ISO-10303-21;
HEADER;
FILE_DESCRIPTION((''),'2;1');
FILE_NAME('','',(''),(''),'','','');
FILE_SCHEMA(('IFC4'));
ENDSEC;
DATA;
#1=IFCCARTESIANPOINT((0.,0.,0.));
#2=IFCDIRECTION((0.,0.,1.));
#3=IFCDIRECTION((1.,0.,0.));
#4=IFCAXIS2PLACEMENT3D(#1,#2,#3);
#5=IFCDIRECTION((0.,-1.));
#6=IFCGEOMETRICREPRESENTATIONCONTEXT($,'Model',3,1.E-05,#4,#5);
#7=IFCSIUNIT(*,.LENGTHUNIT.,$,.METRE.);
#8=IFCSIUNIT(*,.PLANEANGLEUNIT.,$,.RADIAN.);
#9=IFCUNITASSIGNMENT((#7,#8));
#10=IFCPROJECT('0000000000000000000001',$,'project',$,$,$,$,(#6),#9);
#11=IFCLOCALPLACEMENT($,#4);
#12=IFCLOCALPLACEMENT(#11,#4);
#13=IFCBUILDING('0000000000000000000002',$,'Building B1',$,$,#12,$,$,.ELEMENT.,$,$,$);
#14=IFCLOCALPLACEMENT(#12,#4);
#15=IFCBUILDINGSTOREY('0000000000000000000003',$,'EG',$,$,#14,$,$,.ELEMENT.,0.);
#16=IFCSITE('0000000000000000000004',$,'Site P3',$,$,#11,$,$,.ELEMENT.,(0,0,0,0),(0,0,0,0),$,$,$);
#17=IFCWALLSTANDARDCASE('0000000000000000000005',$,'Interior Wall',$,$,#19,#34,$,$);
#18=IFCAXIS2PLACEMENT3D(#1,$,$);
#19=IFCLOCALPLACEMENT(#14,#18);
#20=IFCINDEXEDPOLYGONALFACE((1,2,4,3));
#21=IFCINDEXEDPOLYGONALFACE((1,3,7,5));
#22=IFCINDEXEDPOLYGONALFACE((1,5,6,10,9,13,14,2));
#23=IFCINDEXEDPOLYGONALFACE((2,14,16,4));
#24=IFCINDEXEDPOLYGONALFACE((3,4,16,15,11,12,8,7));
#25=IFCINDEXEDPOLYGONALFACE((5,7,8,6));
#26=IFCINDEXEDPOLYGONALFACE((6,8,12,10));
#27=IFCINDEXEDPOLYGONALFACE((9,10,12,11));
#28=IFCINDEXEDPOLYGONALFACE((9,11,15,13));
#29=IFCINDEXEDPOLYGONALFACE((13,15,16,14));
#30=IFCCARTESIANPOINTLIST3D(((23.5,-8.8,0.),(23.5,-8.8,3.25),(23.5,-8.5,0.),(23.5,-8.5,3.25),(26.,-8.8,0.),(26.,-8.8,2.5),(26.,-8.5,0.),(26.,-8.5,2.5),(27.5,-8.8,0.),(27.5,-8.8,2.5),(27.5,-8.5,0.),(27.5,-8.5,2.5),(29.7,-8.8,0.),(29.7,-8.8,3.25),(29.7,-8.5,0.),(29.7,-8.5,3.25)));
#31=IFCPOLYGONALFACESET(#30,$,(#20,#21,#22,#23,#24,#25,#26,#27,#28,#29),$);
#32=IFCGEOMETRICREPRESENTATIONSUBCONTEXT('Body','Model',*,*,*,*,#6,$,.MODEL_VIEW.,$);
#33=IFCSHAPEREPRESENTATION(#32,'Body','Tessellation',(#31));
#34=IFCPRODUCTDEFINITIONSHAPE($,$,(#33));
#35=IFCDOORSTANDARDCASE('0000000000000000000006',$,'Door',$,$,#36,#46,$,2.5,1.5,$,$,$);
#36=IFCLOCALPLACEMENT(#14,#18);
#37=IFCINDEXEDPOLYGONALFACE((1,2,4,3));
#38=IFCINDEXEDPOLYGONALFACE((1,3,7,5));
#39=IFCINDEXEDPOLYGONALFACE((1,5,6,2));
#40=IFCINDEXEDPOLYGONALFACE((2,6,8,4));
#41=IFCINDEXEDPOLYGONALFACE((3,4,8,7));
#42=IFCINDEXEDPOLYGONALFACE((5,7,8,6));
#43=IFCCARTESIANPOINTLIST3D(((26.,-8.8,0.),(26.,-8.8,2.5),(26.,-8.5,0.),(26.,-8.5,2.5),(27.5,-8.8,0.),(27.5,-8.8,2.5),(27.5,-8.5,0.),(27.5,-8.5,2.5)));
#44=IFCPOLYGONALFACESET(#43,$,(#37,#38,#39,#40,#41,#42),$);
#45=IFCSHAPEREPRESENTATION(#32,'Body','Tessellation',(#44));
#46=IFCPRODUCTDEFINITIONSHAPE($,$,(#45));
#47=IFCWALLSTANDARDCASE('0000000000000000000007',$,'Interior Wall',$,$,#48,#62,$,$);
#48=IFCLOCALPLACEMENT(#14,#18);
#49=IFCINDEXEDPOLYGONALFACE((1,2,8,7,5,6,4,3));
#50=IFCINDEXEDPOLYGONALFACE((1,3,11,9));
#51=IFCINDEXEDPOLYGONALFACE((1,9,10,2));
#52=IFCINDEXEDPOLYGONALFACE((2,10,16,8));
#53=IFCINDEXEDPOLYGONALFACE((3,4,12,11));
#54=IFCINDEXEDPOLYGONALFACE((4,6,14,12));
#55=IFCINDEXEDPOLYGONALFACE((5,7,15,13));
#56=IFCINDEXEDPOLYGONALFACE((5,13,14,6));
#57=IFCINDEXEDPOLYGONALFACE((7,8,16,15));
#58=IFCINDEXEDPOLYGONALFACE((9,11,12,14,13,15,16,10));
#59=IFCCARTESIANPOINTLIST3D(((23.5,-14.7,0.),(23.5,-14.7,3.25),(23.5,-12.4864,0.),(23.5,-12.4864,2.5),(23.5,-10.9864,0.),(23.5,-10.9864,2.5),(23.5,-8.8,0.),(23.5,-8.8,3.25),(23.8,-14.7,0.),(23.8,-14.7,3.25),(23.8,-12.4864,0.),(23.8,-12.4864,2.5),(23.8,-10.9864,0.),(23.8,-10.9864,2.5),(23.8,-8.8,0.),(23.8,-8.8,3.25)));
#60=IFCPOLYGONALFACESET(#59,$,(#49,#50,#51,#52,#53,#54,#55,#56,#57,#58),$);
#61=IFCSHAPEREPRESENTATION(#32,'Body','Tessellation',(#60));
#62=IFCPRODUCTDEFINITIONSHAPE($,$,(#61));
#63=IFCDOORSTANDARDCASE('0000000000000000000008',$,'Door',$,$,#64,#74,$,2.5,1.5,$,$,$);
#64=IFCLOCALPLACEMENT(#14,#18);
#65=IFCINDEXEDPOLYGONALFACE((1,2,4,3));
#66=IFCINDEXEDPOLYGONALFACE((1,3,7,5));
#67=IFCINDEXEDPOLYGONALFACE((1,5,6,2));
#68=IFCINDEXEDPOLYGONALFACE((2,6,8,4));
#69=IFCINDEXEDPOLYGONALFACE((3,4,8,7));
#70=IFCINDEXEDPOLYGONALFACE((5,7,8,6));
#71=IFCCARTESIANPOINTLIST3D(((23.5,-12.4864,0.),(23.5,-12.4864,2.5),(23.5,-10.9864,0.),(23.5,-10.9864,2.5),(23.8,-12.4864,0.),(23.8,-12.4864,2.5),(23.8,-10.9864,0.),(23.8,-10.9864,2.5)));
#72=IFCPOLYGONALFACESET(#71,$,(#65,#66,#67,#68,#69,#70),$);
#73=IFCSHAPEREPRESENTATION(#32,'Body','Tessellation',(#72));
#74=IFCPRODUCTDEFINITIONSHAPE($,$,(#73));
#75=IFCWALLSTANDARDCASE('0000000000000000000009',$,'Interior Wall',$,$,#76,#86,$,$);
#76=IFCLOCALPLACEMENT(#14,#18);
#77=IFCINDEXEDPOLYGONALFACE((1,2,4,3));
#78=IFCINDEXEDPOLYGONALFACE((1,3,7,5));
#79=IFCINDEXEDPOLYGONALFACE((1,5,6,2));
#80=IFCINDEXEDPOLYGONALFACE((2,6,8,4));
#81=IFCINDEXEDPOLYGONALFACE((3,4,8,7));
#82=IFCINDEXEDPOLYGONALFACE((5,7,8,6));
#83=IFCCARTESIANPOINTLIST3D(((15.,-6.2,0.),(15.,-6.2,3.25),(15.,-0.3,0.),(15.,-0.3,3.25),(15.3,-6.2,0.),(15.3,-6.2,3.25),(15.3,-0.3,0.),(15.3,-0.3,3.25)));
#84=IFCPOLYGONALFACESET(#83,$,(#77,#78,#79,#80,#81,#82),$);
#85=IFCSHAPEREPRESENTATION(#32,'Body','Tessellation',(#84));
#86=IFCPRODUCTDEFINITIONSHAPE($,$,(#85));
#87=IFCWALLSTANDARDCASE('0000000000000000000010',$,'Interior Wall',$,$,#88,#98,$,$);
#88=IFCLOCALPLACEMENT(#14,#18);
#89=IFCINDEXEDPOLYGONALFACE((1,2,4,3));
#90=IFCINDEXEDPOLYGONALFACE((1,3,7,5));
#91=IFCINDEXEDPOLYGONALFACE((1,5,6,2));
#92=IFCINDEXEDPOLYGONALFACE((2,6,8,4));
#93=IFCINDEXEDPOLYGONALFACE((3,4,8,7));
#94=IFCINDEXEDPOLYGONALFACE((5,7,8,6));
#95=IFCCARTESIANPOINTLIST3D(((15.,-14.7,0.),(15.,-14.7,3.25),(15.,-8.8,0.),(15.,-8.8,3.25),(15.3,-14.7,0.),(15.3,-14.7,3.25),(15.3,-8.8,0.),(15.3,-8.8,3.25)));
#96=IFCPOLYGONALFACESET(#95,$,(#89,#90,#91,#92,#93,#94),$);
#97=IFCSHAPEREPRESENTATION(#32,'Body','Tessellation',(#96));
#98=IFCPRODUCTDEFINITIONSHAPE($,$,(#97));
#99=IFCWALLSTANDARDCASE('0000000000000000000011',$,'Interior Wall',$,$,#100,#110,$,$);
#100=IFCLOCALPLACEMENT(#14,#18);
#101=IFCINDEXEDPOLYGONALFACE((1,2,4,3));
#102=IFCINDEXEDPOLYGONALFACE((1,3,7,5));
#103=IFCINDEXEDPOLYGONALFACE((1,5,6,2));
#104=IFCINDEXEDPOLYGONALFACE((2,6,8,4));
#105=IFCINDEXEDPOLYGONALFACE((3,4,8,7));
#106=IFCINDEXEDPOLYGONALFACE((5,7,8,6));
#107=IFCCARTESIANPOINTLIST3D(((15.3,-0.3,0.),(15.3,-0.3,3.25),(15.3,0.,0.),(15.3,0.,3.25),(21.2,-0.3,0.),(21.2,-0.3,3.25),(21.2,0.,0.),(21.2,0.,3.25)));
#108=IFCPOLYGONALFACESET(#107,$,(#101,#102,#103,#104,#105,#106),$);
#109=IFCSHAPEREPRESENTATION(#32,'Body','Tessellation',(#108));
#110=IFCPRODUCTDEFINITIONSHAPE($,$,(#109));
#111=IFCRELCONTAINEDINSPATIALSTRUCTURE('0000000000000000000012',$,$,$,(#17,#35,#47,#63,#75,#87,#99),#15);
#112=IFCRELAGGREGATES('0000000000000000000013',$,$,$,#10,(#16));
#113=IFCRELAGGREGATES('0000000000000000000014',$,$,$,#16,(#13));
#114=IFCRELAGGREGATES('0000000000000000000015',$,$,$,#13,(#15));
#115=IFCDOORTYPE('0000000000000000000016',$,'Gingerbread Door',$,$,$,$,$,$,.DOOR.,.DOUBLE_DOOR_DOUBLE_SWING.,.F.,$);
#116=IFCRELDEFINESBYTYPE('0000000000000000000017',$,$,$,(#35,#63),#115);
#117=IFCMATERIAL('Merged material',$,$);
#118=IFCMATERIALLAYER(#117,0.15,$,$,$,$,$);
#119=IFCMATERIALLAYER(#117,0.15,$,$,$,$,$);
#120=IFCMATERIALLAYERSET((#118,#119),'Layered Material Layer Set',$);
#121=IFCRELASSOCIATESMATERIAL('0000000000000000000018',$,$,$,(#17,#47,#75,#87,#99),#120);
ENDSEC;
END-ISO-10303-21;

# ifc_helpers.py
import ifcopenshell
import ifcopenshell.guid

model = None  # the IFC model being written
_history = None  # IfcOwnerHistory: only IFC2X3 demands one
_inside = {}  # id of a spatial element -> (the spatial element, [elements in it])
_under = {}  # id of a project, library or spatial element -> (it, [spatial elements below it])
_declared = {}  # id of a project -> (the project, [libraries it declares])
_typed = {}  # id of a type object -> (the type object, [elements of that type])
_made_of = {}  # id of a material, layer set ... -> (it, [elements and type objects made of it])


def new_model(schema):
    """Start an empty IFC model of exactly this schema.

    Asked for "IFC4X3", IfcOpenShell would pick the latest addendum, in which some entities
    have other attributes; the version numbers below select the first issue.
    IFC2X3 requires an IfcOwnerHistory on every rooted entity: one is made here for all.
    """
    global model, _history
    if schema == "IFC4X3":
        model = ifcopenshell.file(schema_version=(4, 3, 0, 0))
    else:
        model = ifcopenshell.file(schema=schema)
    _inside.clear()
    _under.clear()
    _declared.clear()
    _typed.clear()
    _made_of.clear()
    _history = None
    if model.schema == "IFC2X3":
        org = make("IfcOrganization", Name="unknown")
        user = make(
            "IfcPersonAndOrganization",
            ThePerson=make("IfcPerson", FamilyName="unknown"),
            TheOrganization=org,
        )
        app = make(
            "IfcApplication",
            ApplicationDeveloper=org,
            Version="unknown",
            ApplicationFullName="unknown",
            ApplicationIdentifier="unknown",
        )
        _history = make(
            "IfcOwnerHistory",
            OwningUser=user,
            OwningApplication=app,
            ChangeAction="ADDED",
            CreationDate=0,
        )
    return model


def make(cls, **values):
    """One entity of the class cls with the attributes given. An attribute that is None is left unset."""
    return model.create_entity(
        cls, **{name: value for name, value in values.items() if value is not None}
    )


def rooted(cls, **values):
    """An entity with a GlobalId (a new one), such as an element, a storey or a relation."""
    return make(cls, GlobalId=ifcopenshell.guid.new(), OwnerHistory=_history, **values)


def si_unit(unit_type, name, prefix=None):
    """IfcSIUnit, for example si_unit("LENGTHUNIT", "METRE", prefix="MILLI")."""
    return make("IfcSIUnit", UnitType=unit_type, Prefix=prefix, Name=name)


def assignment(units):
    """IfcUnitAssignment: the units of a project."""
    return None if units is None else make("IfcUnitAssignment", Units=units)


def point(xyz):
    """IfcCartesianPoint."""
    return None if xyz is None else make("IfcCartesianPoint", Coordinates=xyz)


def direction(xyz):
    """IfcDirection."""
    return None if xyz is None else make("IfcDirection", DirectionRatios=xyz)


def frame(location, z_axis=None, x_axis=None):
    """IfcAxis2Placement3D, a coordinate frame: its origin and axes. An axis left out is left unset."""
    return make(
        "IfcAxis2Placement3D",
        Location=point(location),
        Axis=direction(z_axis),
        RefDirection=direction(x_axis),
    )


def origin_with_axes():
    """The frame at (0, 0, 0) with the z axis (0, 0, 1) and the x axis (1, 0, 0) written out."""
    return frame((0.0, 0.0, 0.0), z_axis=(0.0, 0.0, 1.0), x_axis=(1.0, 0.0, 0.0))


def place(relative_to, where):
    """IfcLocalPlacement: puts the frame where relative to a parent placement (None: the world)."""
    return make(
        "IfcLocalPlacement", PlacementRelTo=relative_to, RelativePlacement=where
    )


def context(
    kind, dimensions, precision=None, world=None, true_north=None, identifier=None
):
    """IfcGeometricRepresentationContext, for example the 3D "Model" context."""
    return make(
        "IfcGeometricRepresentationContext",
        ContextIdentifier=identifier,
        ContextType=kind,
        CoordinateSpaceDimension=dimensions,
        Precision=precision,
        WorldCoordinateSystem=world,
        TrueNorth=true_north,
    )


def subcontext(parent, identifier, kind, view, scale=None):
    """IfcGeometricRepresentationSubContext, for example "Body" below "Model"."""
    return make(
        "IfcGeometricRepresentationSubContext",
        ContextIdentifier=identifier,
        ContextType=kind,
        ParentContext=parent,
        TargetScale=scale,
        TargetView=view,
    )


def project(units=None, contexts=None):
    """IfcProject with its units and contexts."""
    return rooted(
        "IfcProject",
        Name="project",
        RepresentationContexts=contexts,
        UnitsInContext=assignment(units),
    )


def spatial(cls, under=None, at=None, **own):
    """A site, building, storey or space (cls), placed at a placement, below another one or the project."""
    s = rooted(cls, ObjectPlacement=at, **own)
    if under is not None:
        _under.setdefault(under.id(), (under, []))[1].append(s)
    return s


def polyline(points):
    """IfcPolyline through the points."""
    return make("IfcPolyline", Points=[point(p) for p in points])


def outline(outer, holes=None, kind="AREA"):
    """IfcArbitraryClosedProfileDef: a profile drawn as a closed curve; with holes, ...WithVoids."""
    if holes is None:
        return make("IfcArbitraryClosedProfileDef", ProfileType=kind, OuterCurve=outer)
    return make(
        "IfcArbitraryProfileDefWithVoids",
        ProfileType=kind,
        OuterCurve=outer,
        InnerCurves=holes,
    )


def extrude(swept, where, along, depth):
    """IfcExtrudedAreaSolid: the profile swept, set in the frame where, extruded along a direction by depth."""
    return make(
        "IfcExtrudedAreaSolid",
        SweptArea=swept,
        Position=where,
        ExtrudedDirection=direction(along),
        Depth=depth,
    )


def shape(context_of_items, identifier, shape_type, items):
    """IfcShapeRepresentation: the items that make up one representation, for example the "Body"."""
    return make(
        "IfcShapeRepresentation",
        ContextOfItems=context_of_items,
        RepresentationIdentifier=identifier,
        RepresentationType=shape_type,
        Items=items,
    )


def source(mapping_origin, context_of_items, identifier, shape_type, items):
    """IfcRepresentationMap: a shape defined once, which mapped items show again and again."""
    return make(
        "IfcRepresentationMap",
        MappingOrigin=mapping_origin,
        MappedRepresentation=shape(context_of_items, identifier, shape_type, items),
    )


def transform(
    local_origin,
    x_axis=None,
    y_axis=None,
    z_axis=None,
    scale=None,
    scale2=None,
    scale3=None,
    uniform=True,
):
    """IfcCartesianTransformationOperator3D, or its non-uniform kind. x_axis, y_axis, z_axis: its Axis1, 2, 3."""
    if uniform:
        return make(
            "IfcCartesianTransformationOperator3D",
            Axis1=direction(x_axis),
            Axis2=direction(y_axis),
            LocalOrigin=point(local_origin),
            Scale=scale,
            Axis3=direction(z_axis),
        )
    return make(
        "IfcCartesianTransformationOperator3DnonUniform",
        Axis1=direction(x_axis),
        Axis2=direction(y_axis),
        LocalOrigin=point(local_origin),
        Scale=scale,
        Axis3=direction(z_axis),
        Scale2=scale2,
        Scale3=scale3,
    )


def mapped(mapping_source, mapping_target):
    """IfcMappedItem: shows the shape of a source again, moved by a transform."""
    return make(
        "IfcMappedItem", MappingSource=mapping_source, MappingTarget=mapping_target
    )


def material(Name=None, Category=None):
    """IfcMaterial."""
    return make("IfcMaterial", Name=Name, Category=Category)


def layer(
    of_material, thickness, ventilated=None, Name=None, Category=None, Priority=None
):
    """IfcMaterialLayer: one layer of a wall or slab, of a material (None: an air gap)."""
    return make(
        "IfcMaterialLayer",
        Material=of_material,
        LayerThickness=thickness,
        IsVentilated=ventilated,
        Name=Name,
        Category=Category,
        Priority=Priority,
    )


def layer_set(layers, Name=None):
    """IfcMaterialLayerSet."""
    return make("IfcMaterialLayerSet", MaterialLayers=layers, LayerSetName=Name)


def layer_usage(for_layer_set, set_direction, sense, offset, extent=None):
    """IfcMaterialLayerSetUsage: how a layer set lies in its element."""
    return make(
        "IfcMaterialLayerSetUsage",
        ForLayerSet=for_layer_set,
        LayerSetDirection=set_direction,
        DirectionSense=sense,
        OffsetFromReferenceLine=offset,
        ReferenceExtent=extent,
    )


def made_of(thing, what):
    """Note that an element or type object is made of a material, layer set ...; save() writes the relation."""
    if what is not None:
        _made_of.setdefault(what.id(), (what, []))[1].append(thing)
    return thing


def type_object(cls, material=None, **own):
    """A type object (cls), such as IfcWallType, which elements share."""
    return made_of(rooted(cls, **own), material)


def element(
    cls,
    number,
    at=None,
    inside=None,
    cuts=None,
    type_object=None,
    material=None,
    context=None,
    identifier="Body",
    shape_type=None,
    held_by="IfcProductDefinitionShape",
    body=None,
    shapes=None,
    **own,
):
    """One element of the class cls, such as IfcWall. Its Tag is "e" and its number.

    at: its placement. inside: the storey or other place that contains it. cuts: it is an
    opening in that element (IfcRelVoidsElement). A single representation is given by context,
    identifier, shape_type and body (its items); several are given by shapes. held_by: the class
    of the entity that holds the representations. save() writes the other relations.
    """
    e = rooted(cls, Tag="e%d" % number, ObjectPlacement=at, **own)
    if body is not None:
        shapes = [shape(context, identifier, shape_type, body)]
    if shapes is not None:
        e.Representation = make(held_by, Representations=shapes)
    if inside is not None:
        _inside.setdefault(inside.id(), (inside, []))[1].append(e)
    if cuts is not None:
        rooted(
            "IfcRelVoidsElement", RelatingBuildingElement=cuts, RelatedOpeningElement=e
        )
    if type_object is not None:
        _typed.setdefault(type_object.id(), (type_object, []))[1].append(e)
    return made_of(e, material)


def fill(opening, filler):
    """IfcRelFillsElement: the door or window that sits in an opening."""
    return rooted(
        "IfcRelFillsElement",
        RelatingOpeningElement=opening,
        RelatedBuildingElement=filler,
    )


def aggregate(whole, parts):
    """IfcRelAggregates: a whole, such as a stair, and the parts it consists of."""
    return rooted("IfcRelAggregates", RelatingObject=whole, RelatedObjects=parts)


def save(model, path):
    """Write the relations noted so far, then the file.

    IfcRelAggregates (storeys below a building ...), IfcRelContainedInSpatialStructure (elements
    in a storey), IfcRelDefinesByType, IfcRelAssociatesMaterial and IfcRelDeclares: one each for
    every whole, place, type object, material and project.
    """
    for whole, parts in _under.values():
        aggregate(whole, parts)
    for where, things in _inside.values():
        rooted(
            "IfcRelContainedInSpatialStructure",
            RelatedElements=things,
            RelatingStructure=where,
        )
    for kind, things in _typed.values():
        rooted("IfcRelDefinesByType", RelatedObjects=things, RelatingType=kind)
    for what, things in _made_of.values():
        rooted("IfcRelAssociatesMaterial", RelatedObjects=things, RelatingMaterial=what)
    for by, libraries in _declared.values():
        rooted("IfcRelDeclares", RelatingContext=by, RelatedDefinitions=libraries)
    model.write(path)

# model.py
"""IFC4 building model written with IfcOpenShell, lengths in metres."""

from ifc_helpers import new_model, si_unit, direction, frame, origin_with_axes, place, context, subcontext, project, spatial, polyline, outline, extrude, source, transform, mapped, material, layer, layer_set, layer_usage, type_object, element, fill, save


model = new_model("IFC4")

# Units and contexts
model_context = context("Model", 3, precision=1e-05, world=origin_with_axes(), true_north=direction((0.0, -1.0)))
body_context = subcontext(model_context, "Body", "Model", "MODEL_VIEW")
ifc_project = project(units=[si_unit("LENGTHUNIT", "METRE"), si_unit("PLANEANGLEUNIT", "RADIAN")], contexts=[model_context])

# Site, building, storey
site_placement = place(None, origin_with_axes())
site = spatial("IfcSite", under=ifc_project, at=site_placement, Name="Site P3", CompositionType="ELEMENT", RefLatitude=(0, 0, 0, 0), RefLongitude=(0, 0, 0, 0))
building_placement = place(site_placement, origin_with_axes())
building = spatial("IfcBuilding", under=site, at=building_placement, Name="Building B1", CompositionType="ELEMENT")
storey_placement = place(building_placement, origin_with_axes())
storey = spatial("IfcBuildingStorey", under=building, at=storey_placement, Name="EG", CompositionType="ELEMENT", Elevation=0.0)

# Shared definitions
ifc_material = material(Name="Merged material")

# Walls, openings, doors
ifc_layer_1 = layer(ifc_material, 0.15)
ifc_layer_2 = layer(ifc_material, 0.15)
ifc_layer_set_1 = layer_set([ifc_layer_1, ifc_layer_2], Name="Layered Material Layer Set")
ifc_layer_usage_1 = layer_usage(ifc_layer_set_1, "AXIS2", "POSITIVE", -0.15)
door_type = type_object("IfcDoorType", Name="Gingerbread Door", OperationType="DOUBLE_DOOR_DOUBLE_SWING", ParameterTakesPrecedence=False, PredefinedType="DOOR")
shared_shape_1 = source(origin_with_axes(), body_context, "Body", "SweptSolid", [
    extrude(outline(polyline([(0.0, 0.0), (0.0, 1.5), (2.5, 1.5), (2.5, 0.0), (0.0, 0.0)])), frame((0.0, -0.15, 0.0), z_axis=(0.0, 1.0, 0.0), x_axis=(0.0, 0.0, 1.0)), (0.0, 0.0, 1.0), 0.3),
])
wall_1_placement = place(storey_placement, frame((23.5, -8.65, 0.0), z_axis=(0.0, 0.0, 1.0), x_axis=(1.0, 0.0, 0.0)))
wall_1 = element("IfcWallStandardCase", 1, at=wall_1_placement, inside=storey, material=ifc_layer_usage_1, Name="Interior Wall", context=body_context, shape_type="SweptSolid", body=[
    extrude(outline(polyline([(0.0, 0.15), (6.2, 0.15), (6.2, -0.15), (0.0, -0.15), (0.0, 0.15)])), origin_with_axes(), (0.0, 0.0, 1.0), 3.25),
])
opening_1_placement = place(wall_1_placement, frame((2.5, 0.0, 0.0), z_axis=(0.0, 0.0, 1.0), x_axis=(1.0, 0.0, 0.0)))
opening_1 = element("IfcOpeningStandardCase", 2, at=opening_1_placement, cuts=wall_1, context=body_context, shape_type="SweptSolid", body=[
    extrude(outline(polyline([(0.0, 0.0), (0.0, 1.5), (2.5, 1.5), (2.5, 0.0), (0.0, 0.0)])), frame((0.0, -0.15, 0.0), z_axis=(0.0, 1.0, 0.0), x_axis=(0.0, 0.0, 1.0)), (0.0, 0.0, 1.0), 0.3),
])
door_1_placement = place(opening_1_placement, origin_with_axes())
door_1 = element("IfcDoorStandardCase", 3, at=door_1_placement, inside=storey, type_object=door_type, Name="Door", OverallHeight=2.5, OverallWidth=1.5, context=body_context, shape_type="MappedRepresentation", body=[
    mapped(shared_shape_1, transform((0.0, 0.0, 0.0))),
])
fill(opening_1, door_1)
wall_2_placement = place(storey_placement, frame((23.65, -8.8, 0.0), z_axis=(0.0, 0.0, 1.0), x_axis=(0.0, -1.0, 0.0)))
wall_2 = element("IfcWallStandardCase", 4, at=wall_2_placement, inside=storey, material=ifc_layer_usage_1, Name="Interior Wall", context=body_context, shape_type="SweptSolid", body=[
    extrude(outline(polyline([(0.0, 0.15), (5.9, 0.15), (5.9, -0.15), (0.0, -0.15), (0.0, 0.15)])), origin_with_axes(), (0.0, 0.0, 1.0), 3.25),
])
opening_2_placement = place(wall_2_placement, frame((2.1864, 0.0, 0.0), z_axis=(0.0, 0.0, 1.0), x_axis=(1.0, 0.0, 0.0)))
opening_2 = element("IfcOpeningStandardCase", 5, at=opening_2_placement, cuts=wall_2, context=body_context, shape_type="SweptSolid", body=[
    extrude(outline(polyline([(0.0, 0.0), (0.0, 1.5), (2.5, 1.5), (2.5, 0.0), (0.0, 0.0)])), frame((0.0, -0.15, 0.0), z_axis=(0.0, 1.0, 0.0), x_axis=(0.0, 0.0, 1.0)), (0.0, 0.0, 1.0), 0.3),
])
door_2_placement = place(opening_2_placement, origin_with_axes())
door_2 = element("IfcDoorStandardCase", 6, at=door_2_placement, inside=storey, type_object=door_type, Name="Door", OverallHeight=2.5, OverallWidth=1.5, context=body_context, shape_type="MappedRepresentation", body=[
    mapped(shared_shape_1, transform((0.0, 0.0, 0.0))),
])
fill(opening_2, door_2)

# Walls
for number, where, z_axis, x_axis, name in (
    (7, (15.15, -0.3, 0.0), (0.0, 0.0, 1.0), (0.0, -1.0, 0.0), "Interior Wall"),
    (8, (15.15, -8.8, 0.0), (0.0, 0.0, 1.0), (0.0, -1.0, 0.0), "Interior Wall"),
    (9, (15.3, -0.15, 0.0), (0.0, 0.0, 1.0), (1.0, 0.0, 0.0), "Interior Wall"),
):
    element("IfcWallStandardCase", number, at=place(storey_placement, frame(where, z_axis=z_axis, x_axis=x_axis)), inside=storey, material=ifc_layer_usage_1, Name=name, context=body_context, shape_type="SweptSolid", body=[
        extrude(outline(polyline([(0.0, 0.15), (5.9, 0.15), (5.9, -0.15), (0.0, -0.15), (0.0, 0.15)])), origin_with_axes(), (0.0, 0.0, 1.0), 3.25),
    ])

save(model, "model.ifc")
